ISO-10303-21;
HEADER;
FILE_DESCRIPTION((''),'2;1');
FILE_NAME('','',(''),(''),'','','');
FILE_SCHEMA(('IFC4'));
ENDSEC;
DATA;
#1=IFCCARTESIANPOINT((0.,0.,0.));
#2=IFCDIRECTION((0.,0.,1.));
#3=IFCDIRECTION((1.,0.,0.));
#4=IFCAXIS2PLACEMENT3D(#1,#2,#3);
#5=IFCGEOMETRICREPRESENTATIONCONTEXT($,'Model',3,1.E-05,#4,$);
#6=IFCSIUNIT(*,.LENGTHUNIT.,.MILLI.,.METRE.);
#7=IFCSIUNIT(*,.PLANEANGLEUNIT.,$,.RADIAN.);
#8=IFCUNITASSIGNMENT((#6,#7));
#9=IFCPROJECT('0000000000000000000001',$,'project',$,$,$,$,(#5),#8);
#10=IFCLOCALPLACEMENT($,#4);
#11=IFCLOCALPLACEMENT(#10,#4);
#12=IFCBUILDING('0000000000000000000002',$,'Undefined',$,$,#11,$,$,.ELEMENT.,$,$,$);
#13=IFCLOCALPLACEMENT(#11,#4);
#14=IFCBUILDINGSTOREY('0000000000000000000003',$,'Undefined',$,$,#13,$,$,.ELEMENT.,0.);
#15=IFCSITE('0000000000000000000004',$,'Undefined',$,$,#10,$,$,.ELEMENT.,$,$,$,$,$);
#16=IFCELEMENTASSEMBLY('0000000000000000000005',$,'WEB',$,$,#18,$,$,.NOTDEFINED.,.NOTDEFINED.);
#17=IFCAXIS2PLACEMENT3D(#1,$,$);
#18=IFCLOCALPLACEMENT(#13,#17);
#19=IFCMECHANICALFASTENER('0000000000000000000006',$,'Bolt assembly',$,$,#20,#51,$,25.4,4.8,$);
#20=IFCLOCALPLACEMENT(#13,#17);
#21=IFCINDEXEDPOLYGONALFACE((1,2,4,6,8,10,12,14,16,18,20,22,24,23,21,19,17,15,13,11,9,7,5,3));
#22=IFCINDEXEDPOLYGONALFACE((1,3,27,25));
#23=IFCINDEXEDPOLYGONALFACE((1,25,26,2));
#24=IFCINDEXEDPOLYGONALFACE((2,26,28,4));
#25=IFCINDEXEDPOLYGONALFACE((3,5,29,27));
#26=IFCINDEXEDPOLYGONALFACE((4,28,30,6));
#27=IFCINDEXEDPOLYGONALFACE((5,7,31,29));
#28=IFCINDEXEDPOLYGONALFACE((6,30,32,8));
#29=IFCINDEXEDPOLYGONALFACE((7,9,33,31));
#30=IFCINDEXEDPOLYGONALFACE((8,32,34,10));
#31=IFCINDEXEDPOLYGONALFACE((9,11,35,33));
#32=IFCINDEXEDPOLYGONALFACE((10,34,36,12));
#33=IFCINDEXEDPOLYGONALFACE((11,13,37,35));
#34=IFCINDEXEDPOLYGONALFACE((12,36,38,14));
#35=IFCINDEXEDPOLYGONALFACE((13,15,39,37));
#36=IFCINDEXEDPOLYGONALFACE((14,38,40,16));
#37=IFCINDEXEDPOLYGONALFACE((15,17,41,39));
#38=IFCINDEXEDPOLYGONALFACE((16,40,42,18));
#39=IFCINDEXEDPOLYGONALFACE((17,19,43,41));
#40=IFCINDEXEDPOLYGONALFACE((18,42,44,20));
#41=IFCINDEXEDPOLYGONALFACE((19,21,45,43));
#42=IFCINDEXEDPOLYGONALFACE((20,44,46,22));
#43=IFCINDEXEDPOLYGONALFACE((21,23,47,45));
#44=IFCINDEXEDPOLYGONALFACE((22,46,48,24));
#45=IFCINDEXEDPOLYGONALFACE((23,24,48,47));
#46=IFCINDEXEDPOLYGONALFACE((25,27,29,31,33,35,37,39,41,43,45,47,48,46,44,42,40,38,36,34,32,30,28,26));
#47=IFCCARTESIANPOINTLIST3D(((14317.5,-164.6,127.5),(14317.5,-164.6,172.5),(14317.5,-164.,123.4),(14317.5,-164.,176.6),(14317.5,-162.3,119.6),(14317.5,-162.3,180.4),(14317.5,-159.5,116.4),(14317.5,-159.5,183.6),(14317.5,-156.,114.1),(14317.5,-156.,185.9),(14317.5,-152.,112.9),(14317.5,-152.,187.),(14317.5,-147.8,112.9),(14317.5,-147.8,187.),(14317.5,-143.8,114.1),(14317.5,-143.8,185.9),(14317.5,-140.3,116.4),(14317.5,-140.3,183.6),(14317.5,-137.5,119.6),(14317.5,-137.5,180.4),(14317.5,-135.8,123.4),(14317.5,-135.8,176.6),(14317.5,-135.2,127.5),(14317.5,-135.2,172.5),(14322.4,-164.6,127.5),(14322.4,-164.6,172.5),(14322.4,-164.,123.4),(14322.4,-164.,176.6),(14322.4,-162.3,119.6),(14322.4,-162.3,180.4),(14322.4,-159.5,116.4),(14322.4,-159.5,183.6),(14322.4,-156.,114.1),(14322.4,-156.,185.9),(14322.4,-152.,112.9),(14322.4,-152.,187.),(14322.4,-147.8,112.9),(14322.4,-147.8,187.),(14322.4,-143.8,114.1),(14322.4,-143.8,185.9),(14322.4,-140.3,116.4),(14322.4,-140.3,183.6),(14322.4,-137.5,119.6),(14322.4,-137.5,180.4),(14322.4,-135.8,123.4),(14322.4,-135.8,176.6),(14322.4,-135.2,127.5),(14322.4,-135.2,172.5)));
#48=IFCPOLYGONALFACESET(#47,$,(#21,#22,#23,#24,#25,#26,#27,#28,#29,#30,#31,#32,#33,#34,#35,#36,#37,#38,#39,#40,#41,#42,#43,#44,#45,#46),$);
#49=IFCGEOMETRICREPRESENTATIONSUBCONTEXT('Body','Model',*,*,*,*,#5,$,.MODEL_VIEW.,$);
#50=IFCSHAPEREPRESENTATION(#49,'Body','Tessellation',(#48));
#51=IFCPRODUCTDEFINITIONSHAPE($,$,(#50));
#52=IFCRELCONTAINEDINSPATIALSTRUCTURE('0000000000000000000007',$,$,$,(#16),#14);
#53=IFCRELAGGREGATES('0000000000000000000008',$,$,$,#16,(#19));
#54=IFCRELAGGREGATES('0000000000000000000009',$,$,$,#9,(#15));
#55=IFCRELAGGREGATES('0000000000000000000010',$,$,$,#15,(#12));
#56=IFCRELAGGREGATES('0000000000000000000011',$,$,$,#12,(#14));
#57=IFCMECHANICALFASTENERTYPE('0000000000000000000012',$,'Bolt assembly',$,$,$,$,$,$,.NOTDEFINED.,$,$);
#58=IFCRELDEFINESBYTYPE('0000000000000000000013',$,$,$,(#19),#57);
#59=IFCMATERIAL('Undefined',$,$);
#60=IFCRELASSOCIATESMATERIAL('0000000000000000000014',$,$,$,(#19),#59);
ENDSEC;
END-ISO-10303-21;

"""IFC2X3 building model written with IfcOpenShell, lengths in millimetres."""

from ifc_helpers import new_model, si_unit, frame, frame_2d, origin_with_axes, place, context, subcontext, project, spatial, polyline, circle_curve, parameter, trimmed, segment, composite_curve, outline, extrude, source, transform, mapped, material, type_object, element, aggregate, save


model = new_model("IFC2X3")

# Units and contexts
model_context = context("Model", 3, precision=1e-05, world=origin_with_axes())
body_context = subcontext(model_context, "Body", "Model", "MODEL_VIEW")
ifc_project = project(units=[si_unit("LENGTHUNIT", "METRE", prefix="MILLI"), si_unit("PLANEANGLEUNIT", "RADIAN")], contexts=[model_context])

# Site, building, storey
site_placement = place(None, origin_with_axes())
site = spatial("IfcSite", under=ifc_project, at=site_placement, Name="Undefined", CompositionType="ELEMENT")
building_placement = place(site_placement, origin_with_axes())
building = spatial("IfcBuilding", under=site, at=building_placement, Name="Undefined", CompositionType="ELEMENT")
storey_placement = place(building_placement, origin_with_axes())
storey = spatial("IfcBuildingStorey", under=building, at=storey_placement, Name="Undefined", CompositionType="ELEMENT", Elevation=0.0)

# Element assembly
assembly_1_placement = place(storey_placement, origin_with_axes())
assembly_1 = element("IfcElementAssembly", 1, at=assembly_1_placement, inside=storey, Name="WEB", AssemblyPlace="NOTDEFINED", PredefinedType="NOTDEFINED")
ifc_material_1 = material(Name="Undefined")
mechanical_fastener_type = type_object("IfcMechanicalFastenerType", Name="Bolt assembly")

# Mechanical fastener
shared_shape_1 = source(origin_with_axes(), body_context, "Body", "SweptSolid", [
    extrude(outline(composite_curve([segment(polyline([(14.7, 22.5), (14.7, -22.5)]), True, "CONTINUOUS"), segment(trimmed(circle_curve(frame_2d((0.0, -22.5), x_axis=(1.0, 0.0)), 14.7), [parameter(0.0)], [parameter(3.141593)], False, "PARAMETER"), True, "CONTINUOUS"), segment(polyline([(-14.7, -22.5), (-14.7, 22.5)]), True, "CONTINUOUS"), segment(trimmed(circle_curve(frame_2d((0.0, 22.5), x_axis=(-1.0, 0.0)), 14.7), [parameter(0.0)], [parameter(3.141593)], False, "PARAMETER"), True, "DISCONTINUOUS")], self_intersect=False)), frame((0.0, -2.4, 0.0), z_axis=(0.0, 1.0, 0.0), x_axis=(1.0, 0.0, 0.0)), (0.0, 0.0, 1.0), 4.9),
])
mechanical_fastener_1_placement = place(assembly_1_placement, frame((14320.0, -149.9, 150.0), z_axis=(0.0, 0.0, -1.0), x_axis=(0.0, -1.0, 0.0)))
mechanical_fastener_1 = element("IfcMechanicalFastener", 2, at=mechanical_fastener_1_placement, type_object=mechanical_fastener_type, material=ifc_material_1, Name="Bolt assembly", NominalDiameter=25.4, NominalLength=4.8, context=body_context, shape_type="MappedRepresentation", body=[
    mapped(shared_shape_1, transform((0.0, 0.0, 0.0))),
])
aggregate(assembly_1, [mechanical_fastener_1])

save(model, "model.ifc")
